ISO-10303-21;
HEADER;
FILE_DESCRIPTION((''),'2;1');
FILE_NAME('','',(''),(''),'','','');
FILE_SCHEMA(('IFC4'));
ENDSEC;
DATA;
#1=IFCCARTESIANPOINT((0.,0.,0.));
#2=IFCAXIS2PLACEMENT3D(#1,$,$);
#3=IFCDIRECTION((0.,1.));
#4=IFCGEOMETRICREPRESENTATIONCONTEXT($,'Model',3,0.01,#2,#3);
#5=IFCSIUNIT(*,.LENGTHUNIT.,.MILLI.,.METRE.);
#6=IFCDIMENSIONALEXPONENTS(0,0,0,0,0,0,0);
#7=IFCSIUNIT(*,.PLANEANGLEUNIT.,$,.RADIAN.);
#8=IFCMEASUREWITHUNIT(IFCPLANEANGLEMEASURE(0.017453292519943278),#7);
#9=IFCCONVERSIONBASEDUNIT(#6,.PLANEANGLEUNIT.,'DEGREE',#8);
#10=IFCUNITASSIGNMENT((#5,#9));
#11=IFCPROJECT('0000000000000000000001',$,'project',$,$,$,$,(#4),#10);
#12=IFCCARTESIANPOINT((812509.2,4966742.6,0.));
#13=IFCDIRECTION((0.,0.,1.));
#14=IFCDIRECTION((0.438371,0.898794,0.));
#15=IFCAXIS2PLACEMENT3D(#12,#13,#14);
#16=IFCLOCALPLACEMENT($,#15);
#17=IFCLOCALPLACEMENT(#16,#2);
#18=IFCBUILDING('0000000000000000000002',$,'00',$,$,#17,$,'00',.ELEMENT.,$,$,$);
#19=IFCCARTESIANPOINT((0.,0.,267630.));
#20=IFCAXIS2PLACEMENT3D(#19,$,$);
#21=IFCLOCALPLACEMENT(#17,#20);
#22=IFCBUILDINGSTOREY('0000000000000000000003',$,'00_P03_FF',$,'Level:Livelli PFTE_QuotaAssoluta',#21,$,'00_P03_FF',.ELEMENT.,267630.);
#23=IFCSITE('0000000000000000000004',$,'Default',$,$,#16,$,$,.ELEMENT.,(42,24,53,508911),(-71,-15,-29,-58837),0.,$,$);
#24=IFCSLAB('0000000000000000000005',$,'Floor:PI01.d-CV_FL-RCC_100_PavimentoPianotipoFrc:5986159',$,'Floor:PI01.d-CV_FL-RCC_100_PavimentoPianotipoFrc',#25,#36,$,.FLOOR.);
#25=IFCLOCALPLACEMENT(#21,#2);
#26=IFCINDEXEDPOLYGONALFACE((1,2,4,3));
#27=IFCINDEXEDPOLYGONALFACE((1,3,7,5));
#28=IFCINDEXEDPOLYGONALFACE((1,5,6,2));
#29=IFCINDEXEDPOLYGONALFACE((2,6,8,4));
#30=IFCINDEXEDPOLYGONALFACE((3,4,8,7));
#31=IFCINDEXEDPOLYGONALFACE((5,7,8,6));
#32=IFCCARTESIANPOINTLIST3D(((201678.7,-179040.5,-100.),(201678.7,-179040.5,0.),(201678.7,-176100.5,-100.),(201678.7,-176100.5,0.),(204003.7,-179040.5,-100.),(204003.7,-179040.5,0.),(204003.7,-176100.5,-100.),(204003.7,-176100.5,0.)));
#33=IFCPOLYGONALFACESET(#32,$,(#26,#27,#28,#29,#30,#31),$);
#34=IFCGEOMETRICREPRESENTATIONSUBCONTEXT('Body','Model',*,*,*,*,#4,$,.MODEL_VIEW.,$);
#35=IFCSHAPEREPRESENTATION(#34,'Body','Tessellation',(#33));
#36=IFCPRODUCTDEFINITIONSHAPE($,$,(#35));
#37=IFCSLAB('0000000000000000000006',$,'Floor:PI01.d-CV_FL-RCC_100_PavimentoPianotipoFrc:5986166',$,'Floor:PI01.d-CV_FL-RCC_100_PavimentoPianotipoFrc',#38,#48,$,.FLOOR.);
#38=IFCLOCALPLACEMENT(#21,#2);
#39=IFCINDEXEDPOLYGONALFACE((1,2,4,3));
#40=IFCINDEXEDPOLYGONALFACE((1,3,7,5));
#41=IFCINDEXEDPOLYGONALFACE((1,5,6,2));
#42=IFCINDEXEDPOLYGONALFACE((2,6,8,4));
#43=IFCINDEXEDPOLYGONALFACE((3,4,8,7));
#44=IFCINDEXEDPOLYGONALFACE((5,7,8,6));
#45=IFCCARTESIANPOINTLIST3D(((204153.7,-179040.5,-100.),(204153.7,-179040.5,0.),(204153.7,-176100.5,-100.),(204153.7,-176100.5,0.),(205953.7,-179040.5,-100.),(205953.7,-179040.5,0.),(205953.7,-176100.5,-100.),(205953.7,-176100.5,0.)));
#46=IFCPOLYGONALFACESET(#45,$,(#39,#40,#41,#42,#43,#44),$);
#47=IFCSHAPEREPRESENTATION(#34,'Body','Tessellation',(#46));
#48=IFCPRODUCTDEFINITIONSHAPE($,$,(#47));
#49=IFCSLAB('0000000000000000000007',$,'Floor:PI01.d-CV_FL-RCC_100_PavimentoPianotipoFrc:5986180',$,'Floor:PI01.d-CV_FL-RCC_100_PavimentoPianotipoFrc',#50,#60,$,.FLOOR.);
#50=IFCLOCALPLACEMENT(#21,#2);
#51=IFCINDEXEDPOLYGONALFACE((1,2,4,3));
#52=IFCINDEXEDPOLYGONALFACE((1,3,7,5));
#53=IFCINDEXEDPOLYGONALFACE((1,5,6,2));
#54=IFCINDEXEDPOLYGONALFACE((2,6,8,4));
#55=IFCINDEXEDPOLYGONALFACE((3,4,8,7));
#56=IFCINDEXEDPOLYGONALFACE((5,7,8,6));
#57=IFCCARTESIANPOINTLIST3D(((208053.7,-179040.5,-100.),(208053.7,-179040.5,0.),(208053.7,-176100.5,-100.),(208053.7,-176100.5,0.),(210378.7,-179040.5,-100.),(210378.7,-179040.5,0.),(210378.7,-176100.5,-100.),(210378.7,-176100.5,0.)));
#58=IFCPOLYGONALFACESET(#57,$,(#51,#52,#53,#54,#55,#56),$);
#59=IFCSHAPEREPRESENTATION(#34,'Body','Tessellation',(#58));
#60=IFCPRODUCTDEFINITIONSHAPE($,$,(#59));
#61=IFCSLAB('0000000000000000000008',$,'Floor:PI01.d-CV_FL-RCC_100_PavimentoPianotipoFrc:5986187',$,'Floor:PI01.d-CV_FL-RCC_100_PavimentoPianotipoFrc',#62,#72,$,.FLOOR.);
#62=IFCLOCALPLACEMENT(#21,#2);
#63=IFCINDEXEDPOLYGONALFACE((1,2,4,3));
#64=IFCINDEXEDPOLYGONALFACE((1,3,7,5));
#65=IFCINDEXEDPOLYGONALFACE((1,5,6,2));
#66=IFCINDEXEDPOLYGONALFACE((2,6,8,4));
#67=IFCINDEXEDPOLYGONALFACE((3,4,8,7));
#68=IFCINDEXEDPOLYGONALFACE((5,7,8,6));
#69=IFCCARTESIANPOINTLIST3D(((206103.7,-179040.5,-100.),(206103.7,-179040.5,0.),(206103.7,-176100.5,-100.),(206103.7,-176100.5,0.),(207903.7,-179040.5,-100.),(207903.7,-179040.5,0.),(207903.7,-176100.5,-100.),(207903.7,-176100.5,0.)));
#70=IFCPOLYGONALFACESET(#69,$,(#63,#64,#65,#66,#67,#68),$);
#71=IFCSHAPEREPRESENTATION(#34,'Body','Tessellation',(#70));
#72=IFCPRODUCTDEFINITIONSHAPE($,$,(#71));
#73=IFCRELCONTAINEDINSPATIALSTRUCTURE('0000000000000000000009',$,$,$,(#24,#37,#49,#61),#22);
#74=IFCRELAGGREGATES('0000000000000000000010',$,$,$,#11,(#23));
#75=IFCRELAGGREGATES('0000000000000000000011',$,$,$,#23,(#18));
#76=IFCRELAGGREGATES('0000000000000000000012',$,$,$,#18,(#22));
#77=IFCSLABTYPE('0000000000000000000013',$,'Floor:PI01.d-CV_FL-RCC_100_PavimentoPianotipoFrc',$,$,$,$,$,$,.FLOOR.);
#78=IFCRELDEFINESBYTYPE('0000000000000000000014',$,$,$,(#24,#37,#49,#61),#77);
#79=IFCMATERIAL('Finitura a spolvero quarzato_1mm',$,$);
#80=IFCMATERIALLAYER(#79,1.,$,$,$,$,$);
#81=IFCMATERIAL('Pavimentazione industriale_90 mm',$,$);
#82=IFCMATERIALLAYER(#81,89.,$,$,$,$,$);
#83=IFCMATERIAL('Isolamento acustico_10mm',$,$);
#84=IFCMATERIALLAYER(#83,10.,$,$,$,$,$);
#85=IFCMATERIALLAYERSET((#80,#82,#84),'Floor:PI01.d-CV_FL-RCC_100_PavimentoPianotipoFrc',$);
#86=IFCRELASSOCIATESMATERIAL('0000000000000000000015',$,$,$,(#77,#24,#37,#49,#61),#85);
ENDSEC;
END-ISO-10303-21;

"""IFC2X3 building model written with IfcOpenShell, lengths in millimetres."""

from ifc_helpers import new_model, entity, si_unit, converted_unit, direction, frame, frame_2d, origin, place, context, subcontext, project, spatial, rectangle, extrude, material, layer, layer_set, layer_usage, type_object, element, save


model = new_model("IFC2X3")

# Units and contexts
model_context = context("Model", 3, precision=0.01, world=origin(), true_north=direction((0.0, 1.0)))
body_context = subcontext(model_context, "Body", "Model", "MODEL_VIEW")
ifc_project = project(units=[si_unit("LENGTHUNIT", "METRE", prefix="MILLI"), converted_unit("PLANEANGLEUNIT", "DEGREE", entity("IfcPlaneAngleMeasure", 0.017453292519943278), si_unit("PLANEANGLEUNIT", "RADIAN"), dimensions=[0, 0, 0, 0, 0, 0, 0])], contexts=[model_context])

# Site, building, storey
site_placement = place(None, frame((812509.2, 4966742.6, 0.0), z_axis=(0.0, 0.0, 1.0), x_axis=(0.438371, 0.898794, 0.0)))
site = spatial("IfcSite", under=ifc_project, at=site_placement, Name="Default", CompositionType="ELEMENT", RefLatitude=(42, 24, 53, 508911), RefLongitude=(-71, -15, -29, -58837), RefElevation=0.0)
building_placement = place(site_placement, origin())
building = spatial("IfcBuilding", under=site, at=building_placement, Name="00", LongName="00", CompositionType="ELEMENT")
storey_placement = place(building_placement, frame((0.0, 0.0, 267630.0)))
storey = spatial("IfcBuildingStorey", under=building, at=storey_placement, Name="00_P03_FF", ObjectType="Level:Livelli PFTE_QuotaAssoluta", LongName="00_P03_FF", CompositionType="ELEMENT", Elevation=267630.0)

# Slabs
ifc_material_1 = material(Name="Isolamento acustico_10mm")
ifc_material_2 = material(Name="Finitura a spolvero quarzato_1mm")
ifc_layer_1 = layer(ifc_material_2, 1.0)
ifc_material_3 = material(Name="Pavimentazione industriale_90 mm")
ifc_layer_2 = layer(ifc_material_3, 89.0)
ifc_layer_3 = layer(ifc_material_1, 10.0)
ifc_layer_set_1 = layer_set([ifc_layer_1, ifc_layer_2, ifc_layer_3], Name="Floor:PI01.d-CV_FL-RCC_100_PavimentoPianotipoFrc")
ifc_layer_usage_1 = layer_usage(ifc_layer_set_1, "AXIS3", "POSITIVE", 0.0)
slab_type_1 = type_object("IfcSlabType", Name="Floor:PI01.d-CV_FL-RCC_100_PavimentoPianotipoFrc", PredefinedType="FLOOR", material=ifc_layer_set_1)
slab_1_placement = place(storey_placement, origin())
element("IfcSlab", 1, at=slab_1_placement, inside=storey, type_object=slab_type_1, material=ifc_layer_usage_1, Name="Floor:PI01.d-CV_FL-RCC_100_PavimentoPianotipoFrc:5986159", ObjectType="Floor:PI01.d-CV_FL-RCC_100_PavimentoPianotipoFrc", PredefinedType="FLOOR", context=body_context, shape_type="SweptSolid", body=[
    extrude(rectangle(XDim=2940.0, YDim=2325.0, at=frame_2d((0.0, 0.0), x_axis=(1.0, 0.0))), frame((202841.2, -177570.5, 0.0), z_axis=(0.0, 0.0, -1.0), x_axis=(0.0, 1.0, 0.0)), (0.0, 0.0, 1.0), 100.0),
])
ifc_layer_usage_2 = layer_usage(ifc_layer_set_1, "AXIS3", "POSITIVE", 0.0)
slab_2_placement = place(storey_placement, origin())
element("IfcSlab", 2, at=slab_2_placement, inside=storey, type_object=slab_type_1, material=ifc_layer_usage_2, Name="Floor:PI01.d-CV_FL-RCC_100_PavimentoPianotipoFrc:5986166", ObjectType="Floor:PI01.d-CV_FL-RCC_100_PavimentoPianotipoFrc", PredefinedType="FLOOR", context=body_context, shape_type="SweptSolid", body=[
    extrude(rectangle(XDim=2940.0, YDim=1800.0, at=frame_2d((0.0, 0.0), x_axis=(1.0, 0.0))), frame((205053.7, -177570.5, 0.0), z_axis=(0.0, 0.0, -1.0), x_axis=(0.0, 1.0, 0.0)), (0.0, 0.0, 1.0), 100.0),
])
ifc_layer_usage_3 = layer_usage(ifc_layer_set_1, "AXIS3", "POSITIVE", 0.0)
slab_3_placement = place(storey_placement, origin())
element("IfcSlab", 3, at=slab_3_placement, inside=storey, type_object=slab_type_1, material=ifc_layer_usage_3, Name="Floor:PI01.d-CV_FL-RCC_100_PavimentoPianotipoFrc:5986180", ObjectType="Floor:PI01.d-CV_FL-RCC_100_PavimentoPianotipoFrc", PredefinedType="FLOOR", context=body_context, shape_type="SweptSolid", body=[
    extrude(rectangle(XDim=2940.0, YDim=2325.0, at=frame_2d((0.0, 0.0), x_axis=(1.0, 0.0))), frame((209216.2, -177570.5, 0.0), z_axis=(0.0, 0.0, -1.0), x_axis=(0.0, 1.0, 0.0)), (0.0, 0.0, 1.0), 100.0),
])
ifc_layer_usage_4 = layer_usage(ifc_layer_set_1, "AXIS3", "POSITIVE", 0.0)
slab_4_placement = place(storey_placement, origin())
element("IfcSlab", 4, at=slab_4_placement, inside=storey, type_object=slab_type_1, material=ifc_layer_usage_4, Name="Floor:PI01.d-CV_FL-RCC_100_PavimentoPianotipoFrc:5986187", ObjectType="Floor:PI01.d-CV_FL-RCC_100_PavimentoPianotipoFrc", PredefinedType="FLOOR", context=body_context, shape_type="SweptSolid", body=[
    extrude(rectangle(XDim=2940.0, YDim=1800.0, at=frame_2d((0.0, 0.0), x_axis=(1.0, 0.0))), frame((207003.7, -177570.5, 0.0), z_axis=(0.0, 0.0, -1.0), x_axis=(0.0, 1.0, 0.0)), (0.0, 0.0, 1.0), 100.0),
])

save(model, "model.ifc")
